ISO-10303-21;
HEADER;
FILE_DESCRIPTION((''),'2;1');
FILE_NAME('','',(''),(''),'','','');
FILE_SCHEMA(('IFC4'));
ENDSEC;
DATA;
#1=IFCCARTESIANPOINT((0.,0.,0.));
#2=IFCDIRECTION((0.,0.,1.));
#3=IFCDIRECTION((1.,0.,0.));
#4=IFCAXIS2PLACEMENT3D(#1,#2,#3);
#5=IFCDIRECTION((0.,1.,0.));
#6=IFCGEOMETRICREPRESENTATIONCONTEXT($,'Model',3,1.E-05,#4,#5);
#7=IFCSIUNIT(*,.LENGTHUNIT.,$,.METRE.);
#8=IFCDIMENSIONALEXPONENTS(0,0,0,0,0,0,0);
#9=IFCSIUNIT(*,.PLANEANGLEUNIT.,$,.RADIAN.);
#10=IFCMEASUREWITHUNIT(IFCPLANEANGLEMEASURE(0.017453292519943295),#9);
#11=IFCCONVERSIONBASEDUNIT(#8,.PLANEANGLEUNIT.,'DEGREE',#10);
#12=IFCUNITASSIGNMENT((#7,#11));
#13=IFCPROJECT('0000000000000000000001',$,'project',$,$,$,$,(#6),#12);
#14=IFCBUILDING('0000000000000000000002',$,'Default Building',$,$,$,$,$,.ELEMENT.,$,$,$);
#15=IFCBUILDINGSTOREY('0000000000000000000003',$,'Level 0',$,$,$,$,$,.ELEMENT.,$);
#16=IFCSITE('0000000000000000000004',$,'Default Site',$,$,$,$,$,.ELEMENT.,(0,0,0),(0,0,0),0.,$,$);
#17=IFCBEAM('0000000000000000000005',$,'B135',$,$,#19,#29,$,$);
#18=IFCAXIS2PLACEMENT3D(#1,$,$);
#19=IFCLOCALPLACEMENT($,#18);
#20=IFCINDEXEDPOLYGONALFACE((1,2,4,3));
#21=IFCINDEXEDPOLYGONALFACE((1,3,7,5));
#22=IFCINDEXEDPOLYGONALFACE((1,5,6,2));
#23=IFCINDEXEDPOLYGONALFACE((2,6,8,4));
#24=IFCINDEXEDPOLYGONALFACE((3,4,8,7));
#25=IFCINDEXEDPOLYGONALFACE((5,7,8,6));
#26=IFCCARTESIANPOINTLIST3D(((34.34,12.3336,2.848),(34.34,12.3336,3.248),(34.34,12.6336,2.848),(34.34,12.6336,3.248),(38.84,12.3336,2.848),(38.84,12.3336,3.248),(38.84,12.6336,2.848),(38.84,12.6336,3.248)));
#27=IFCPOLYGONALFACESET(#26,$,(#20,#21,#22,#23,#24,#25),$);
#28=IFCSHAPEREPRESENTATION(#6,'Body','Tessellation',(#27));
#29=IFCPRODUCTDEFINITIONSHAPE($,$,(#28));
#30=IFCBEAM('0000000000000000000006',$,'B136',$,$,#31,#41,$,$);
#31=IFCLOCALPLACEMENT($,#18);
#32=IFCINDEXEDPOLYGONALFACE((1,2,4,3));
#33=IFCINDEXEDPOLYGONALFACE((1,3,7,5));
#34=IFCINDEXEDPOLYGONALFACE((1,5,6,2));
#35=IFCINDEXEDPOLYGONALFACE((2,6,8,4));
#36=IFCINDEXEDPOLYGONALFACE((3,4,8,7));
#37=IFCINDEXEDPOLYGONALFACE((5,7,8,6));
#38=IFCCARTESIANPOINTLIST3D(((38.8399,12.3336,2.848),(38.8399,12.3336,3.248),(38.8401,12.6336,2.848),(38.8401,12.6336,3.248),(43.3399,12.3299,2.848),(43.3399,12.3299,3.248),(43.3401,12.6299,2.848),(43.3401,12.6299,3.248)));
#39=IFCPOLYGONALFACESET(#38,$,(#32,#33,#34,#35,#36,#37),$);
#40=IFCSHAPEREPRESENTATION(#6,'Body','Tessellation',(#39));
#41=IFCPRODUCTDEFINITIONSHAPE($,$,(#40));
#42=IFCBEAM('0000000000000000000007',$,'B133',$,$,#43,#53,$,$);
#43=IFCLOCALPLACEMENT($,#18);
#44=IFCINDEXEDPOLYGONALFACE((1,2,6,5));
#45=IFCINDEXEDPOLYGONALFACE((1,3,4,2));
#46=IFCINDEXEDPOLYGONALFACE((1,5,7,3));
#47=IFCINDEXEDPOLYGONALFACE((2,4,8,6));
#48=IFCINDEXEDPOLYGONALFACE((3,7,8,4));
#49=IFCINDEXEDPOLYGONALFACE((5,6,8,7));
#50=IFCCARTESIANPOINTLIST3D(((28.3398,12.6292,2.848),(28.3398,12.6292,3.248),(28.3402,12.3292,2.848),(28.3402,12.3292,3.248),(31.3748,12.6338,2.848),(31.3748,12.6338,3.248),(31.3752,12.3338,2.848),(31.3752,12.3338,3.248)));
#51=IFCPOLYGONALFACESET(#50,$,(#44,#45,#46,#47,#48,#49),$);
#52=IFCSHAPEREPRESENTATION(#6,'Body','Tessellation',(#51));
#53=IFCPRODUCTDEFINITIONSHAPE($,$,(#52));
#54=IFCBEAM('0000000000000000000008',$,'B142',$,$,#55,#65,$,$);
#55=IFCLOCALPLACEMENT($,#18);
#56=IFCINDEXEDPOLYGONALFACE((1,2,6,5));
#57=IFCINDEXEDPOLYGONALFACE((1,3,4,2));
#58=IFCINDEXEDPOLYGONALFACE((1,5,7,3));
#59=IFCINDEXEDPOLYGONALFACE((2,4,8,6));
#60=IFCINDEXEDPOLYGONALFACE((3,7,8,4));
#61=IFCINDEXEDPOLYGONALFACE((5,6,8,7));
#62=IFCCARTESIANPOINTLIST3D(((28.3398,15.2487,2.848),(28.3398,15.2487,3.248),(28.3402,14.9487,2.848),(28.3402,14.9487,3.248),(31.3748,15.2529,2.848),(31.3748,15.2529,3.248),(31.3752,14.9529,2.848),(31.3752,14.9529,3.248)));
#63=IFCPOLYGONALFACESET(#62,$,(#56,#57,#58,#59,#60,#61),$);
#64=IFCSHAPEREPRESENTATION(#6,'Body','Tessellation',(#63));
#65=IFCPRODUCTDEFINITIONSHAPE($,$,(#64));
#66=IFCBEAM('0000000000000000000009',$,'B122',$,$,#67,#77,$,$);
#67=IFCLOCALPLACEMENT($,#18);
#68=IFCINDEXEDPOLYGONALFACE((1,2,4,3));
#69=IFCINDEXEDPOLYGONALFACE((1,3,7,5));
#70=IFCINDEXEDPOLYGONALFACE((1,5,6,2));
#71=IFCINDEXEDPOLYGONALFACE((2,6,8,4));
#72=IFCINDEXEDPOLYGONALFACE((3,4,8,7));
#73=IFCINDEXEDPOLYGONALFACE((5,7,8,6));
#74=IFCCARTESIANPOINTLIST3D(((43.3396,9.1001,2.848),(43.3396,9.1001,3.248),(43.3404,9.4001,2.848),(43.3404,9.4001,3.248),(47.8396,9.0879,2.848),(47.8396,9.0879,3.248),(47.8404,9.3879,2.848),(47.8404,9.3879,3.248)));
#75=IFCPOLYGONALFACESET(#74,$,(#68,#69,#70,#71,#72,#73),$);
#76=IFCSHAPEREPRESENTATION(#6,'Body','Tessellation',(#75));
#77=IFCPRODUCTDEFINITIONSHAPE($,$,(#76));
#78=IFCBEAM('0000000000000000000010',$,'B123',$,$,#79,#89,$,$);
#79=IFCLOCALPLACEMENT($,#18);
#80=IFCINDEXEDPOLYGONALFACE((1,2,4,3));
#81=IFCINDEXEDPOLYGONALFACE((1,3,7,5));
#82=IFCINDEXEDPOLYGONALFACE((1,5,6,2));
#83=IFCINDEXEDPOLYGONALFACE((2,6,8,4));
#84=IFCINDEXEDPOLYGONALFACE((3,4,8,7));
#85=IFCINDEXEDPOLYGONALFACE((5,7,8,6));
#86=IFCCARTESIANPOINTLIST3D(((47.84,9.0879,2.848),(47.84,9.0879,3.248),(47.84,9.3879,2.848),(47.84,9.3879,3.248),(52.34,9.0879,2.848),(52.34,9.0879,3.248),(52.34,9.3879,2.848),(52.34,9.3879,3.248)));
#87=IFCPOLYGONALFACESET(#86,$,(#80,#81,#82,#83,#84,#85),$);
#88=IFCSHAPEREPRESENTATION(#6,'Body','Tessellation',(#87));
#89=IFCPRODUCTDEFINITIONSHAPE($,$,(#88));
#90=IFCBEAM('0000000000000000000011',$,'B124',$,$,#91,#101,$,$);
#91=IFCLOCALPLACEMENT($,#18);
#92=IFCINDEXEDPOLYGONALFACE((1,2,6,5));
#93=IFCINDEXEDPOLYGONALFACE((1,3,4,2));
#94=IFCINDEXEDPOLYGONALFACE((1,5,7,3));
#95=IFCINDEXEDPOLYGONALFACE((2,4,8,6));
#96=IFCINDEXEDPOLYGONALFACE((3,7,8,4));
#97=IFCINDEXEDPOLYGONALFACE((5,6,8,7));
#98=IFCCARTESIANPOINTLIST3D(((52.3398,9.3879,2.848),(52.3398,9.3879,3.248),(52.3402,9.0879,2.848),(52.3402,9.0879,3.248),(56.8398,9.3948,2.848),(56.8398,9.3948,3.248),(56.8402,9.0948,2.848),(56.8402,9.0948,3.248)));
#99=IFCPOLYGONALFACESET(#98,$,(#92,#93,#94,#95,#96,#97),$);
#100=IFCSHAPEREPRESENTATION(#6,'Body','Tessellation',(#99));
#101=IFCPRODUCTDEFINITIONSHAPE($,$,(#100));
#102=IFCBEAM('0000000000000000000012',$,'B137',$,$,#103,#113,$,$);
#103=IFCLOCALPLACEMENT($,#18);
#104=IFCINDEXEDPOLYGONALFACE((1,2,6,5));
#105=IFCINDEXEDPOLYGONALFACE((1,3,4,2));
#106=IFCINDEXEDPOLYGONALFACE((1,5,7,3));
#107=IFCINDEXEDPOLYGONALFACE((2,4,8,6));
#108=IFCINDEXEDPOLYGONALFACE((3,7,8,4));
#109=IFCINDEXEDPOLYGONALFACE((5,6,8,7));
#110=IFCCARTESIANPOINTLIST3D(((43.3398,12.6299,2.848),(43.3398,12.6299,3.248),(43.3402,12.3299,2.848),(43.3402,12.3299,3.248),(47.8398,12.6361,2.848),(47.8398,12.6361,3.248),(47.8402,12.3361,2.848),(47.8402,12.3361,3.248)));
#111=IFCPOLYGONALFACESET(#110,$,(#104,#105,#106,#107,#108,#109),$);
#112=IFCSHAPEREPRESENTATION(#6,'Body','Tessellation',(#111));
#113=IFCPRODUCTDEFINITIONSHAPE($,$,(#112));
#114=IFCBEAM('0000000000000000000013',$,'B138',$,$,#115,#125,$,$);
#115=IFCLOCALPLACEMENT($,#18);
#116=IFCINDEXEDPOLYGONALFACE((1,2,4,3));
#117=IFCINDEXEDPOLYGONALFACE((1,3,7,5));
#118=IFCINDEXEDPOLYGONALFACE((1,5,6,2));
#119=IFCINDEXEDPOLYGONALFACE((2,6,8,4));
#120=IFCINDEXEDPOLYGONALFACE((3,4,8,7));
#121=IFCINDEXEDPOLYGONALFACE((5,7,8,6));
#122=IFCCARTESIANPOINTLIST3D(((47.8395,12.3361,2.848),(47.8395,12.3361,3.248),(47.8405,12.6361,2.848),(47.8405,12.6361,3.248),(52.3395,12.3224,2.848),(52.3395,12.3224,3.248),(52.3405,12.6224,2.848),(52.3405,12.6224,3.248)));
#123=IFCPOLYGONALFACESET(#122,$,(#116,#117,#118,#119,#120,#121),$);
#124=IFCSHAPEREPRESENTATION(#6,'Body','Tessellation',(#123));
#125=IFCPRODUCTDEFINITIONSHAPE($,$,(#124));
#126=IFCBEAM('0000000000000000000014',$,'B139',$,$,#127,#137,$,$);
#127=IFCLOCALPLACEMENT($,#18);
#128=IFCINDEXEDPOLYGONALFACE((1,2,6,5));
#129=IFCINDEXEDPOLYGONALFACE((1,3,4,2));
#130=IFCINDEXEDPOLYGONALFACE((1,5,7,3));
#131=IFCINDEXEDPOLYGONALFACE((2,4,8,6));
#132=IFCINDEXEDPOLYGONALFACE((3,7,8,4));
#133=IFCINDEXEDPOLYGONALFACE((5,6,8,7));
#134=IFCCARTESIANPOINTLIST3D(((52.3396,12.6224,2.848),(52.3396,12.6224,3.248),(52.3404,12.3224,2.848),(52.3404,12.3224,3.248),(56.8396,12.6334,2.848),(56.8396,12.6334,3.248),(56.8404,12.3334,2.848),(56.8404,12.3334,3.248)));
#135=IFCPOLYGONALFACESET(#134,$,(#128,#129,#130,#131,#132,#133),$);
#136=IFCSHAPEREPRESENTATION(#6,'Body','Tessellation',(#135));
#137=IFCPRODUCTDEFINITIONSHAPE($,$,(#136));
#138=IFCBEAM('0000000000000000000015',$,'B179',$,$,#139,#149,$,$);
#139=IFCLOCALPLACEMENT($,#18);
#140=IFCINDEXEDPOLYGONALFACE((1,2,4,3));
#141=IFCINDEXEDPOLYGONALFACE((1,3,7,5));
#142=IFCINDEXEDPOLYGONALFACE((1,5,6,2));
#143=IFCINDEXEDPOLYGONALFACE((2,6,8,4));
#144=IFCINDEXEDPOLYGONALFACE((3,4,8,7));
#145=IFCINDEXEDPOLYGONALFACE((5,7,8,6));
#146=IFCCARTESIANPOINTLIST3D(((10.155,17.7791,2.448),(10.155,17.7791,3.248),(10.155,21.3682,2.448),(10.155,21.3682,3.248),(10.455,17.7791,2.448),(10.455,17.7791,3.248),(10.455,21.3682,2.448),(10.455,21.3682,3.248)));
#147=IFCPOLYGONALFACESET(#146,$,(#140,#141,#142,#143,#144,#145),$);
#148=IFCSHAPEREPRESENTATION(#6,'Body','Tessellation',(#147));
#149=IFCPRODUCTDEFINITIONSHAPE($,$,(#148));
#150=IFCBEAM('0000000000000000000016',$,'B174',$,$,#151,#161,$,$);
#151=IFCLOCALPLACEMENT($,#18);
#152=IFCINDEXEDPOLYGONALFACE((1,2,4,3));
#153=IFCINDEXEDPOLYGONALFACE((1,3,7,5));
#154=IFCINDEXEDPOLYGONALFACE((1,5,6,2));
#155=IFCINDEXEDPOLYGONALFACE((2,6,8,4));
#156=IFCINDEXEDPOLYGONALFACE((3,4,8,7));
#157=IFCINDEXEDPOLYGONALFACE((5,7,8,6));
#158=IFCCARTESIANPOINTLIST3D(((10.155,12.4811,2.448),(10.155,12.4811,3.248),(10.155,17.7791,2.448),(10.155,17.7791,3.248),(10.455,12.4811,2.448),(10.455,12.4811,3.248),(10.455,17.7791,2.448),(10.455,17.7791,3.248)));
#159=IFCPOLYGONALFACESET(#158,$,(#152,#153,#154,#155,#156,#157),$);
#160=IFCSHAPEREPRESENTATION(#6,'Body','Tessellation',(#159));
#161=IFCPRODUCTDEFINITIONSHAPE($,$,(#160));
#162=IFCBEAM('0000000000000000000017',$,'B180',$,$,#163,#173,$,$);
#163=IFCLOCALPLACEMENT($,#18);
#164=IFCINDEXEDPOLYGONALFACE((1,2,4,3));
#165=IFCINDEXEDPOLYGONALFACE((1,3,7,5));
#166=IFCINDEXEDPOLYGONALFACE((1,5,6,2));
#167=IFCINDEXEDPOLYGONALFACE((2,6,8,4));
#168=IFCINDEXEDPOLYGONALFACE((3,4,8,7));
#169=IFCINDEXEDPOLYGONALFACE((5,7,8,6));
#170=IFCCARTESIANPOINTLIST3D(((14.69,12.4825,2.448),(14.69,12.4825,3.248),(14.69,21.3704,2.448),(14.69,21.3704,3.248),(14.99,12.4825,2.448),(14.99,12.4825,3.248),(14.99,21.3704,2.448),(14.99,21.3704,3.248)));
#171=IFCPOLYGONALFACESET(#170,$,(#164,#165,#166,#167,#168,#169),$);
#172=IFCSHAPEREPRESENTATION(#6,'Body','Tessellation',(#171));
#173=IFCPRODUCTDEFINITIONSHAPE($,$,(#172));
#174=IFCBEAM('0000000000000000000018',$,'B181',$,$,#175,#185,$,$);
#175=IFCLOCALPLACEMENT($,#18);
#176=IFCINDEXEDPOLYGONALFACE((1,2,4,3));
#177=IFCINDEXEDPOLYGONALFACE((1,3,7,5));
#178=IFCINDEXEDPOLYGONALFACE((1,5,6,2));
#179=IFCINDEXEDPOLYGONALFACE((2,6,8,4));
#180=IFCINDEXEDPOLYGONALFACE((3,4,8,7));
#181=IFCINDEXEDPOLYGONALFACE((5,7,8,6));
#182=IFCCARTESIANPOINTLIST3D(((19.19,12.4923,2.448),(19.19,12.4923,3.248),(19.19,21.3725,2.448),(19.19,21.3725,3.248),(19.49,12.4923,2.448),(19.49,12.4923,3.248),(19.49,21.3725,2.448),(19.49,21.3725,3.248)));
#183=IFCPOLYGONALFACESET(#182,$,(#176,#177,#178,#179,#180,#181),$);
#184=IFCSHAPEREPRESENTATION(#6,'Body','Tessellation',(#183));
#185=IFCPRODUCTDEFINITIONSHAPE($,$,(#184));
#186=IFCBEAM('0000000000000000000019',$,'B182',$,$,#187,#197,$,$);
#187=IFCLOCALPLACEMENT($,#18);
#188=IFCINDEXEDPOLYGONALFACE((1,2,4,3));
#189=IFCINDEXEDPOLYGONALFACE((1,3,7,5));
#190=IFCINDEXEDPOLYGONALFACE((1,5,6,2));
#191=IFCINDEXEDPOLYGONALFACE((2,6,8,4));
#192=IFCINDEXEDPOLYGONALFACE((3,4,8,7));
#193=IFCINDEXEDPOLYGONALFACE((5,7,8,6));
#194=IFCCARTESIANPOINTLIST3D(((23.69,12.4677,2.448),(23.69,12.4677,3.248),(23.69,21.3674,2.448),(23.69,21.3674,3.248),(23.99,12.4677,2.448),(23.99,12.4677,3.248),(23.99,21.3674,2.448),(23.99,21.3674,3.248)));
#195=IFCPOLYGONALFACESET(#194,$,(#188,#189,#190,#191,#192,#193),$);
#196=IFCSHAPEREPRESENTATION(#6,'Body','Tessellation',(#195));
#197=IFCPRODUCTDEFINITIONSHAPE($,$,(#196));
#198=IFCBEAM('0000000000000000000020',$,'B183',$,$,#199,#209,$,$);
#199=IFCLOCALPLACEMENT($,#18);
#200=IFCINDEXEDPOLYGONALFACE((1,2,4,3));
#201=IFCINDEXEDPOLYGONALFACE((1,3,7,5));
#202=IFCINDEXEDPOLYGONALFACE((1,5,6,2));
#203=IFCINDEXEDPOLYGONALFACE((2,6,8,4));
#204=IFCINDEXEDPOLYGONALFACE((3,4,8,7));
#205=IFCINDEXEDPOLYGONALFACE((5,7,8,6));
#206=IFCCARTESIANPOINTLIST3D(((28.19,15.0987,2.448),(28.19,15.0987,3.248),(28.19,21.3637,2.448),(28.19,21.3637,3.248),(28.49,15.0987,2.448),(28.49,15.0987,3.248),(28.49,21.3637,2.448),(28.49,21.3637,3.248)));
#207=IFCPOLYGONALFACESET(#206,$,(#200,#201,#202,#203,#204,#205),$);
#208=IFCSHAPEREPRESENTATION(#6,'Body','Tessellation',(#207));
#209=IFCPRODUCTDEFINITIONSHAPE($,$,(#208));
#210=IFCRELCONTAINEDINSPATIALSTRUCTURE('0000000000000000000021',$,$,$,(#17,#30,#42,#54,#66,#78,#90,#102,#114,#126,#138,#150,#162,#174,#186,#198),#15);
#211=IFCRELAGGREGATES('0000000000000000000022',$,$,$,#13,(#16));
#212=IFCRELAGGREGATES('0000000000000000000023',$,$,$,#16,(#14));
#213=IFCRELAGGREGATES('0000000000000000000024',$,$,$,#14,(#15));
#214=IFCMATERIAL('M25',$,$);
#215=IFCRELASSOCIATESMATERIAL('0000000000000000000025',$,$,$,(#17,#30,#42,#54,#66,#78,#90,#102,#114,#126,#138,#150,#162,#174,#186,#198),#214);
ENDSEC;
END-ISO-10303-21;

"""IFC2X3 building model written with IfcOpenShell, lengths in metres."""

from ifc_helpers import new_model, entity, si_unit, converted_unit, direction, frame, frame_2d, origin_with_axes, place, context, project, spatial, rectangle, extrude, material, element, save


model = new_model("IFC2X3")

# Units and contexts
model_context = context("Model", 3, precision=1e-05, world=origin_with_axes(), true_north=direction((0.0, 1.0, 0.0)))
ifc_project = project(units=[si_unit("LENGTHUNIT", "METRE"), converted_unit("PLANEANGLEUNIT", "DEGREE", entity("IfcPlaneAngleMeasure", 0.017453292519943295), si_unit("PLANEANGLEUNIT", "RADIAN"), dimensions=[0, 0, 0, 0, 0, 0, 0])], contexts=[model_context])

# Site, building, storey
site = spatial("IfcSite", under=ifc_project, Name="Default Site", CompositionType="ELEMENT", RefLatitude=(0, 0, 0), RefLongitude=(0, 0, 0), RefElevation=0.0)
building = spatial("IfcBuilding", under=site, Name="Default Building", CompositionType="ELEMENT")
storey = spatial("IfcBuildingStorey", under=building, Name="Level 0", CompositionType="ELEMENT")

# Beams
ifc_material = material(Name="M25")
placement = place(None, origin_with_axes())
element("IfcBeam", 1, at=placement, inside=storey, material=ifc_material, Name="B135", context=model_context, shape_type="SweptSolid", body=[
    extrude(rectangle(XDim=0.3, YDim=0.4, at=frame_2d((0.0, 0.0), x_axis=(0.0, 1.0, 0.0))), frame((34.34, 12.4836, 3.048), z_axis=(1.0, -0.000008, 0.0), x_axis=(0.0, 0.0, -1.0)), (0.0, 0.0, 1.0), 4.5),
])
element("IfcBeam", 2, at=placement, inside=storey, material=ifc_material, Name="B136", context=model_context, shape_type="SweptSolid", body=[
    extrude(rectangle(XDim=0.3, YDim=0.4, at=frame_2d((0.0, 0.0), x_axis=(0.0, 1.0, 0.0))), frame((38.84, 12.4836, 3.048), z_axis=(1.0, -0.000826, 0.0), x_axis=(0.0, 0.0, -1.0)), (0.0, 0.0, 1.0), 4.5),
])
element("IfcBeam", 3, at=placement, inside=storey, material=ifc_material, Name="B133", context=model_context, shape_type="SweptSolid", body=[
    extrude(rectangle(XDim=0.3, YDim=0.4, at=frame_2d((0.0, 0.0), x_axis=(0.0, 1.0, 0.0))), frame((28.34, 12.4792, 3.048), z_axis=(0.999999, 0.001542, 0.0), x_axis=(0.0, 0.0, -1.0)), (0.0, 0.0, 1.0), 3.035),
])
element("IfcBeam", 4, at=placement, inside=storey, material=ifc_material, Name="B142", context=model_context, shape_type="SweptSolid", body=[
    extrude(rectangle(XDim=0.3, YDim=0.4, at=frame_2d((0.0, 0.0), x_axis=(0.0, 1.0, 0.0))), frame((31.375, 15.1029, 3.048), z_axis=(-0.999999, -0.001391, 0.0), x_axis=(0.0, 0.0, -1.0)), (0.0, 0.0, 1.0), 3.035),
])
element("IfcBeam", 5, at=placement, inside=storey, material=ifc_material, Name="B122", context=model_context, shape_type="SweptSolid", body=[
    extrude(rectangle(XDim=0.3, YDim=0.4, at=frame_2d((0.0, 0.0), x_axis=(0.0, 1.0, 0.0))), frame((43.34, 9.2501, 3.048), z_axis=(0.999996, -0.002702, 0.0), x_axis=(0.0, 0.0, -1.0)), (0.0, 0.0, 1.0), 4.5),
])
element("IfcBeam", 6, at=placement, inside=storey, material=ifc_material, Name="B123", context=model_context, shape_type="SweptSolid", body=[
    extrude(rectangle(XDim=0.3, YDim=0.4, at=frame_2d((0.0, 0.0), x_axis=(0.0, 1.0, 0.0))), frame((47.84, 9.2379, 3.048), z_axis=(1.0, 0.0, 0.0), x_axis=(0.0, 0.0, -1.0)), (0.0, 0.0, 1.0), 4.5),
])
element("IfcBeam", 7, at=placement, inside=storey, material=ifc_material, Name="B124", context=model_context, shape_type="SweptSolid", body=[
    extrude(rectangle(XDim=0.3, YDim=0.4, at=frame_2d((0.0, 0.0), x_axis=(0.0, 1.0, 0.0))), frame((52.34, 9.2379, 3.048), z_axis=(0.999999, 0.001537, 0.0), x_axis=(0.0, 0.0, -1.0)), (0.0, 0.0, 1.0), 4.5),
])
element("IfcBeam", 8, at=placement, inside=storey, material=ifc_material, Name="B137", context=model_context, shape_type="SweptSolid", body=[
    extrude(rectangle(XDim=0.3, YDim=0.4, at=frame_2d((0.0, 0.0), x_axis=(0.0, 1.0, 0.0))), frame((43.34, 12.4799, 3.048), z_axis=(0.999999, 0.001374, 0.0), x_axis=(0.0, 0.0, -1.0)), (0.0, 0.0, 1.0), 4.5),
])
element("IfcBeam", 9, at=placement, inside=storey, material=ifc_material, Name="B138", context=model_context, shape_type="SweptSolid", body=[
    extrude(rectangle(XDim=0.3, YDim=0.4, at=frame_2d((0.0, 0.0), x_axis=(0.0, 1.0, 0.0))), frame((47.84, 12.4861, 3.048), z_axis=(0.999995, -0.003045, 0.0), x_axis=(0.0, 0.0, -1.0)), (0.0, 0.0, 1.0), 4.5),
])
element("IfcBeam", 10, at=placement, inside=storey, material=ifc_material, Name="B139", context=model_context, shape_type="SweptSolid", body=[
    extrude(rectangle(XDim=0.3, YDim=0.4, at=frame_2d((0.0, 0.0), x_axis=(0.0, 1.0, 0.0))), frame((52.34, 12.4724, 3.048), z_axis=(0.999997, 0.002456, 0.0), x_axis=(0.0, 0.0, -1.0)), (0.0, 0.0, 1.0), 4.5),
])
element("IfcBeam", 11, at=placement, inside=storey, material=ifc_material, Name="B179", context=model_context, shape_type="SweptSolid", body=[
    extrude(rectangle(XDim=0.3, YDim=0.8, at=frame_2d((0.0, 0.0), x_axis=(0.0, 1.0, 0.0))), frame((10.305, 21.3682, 2.848), z_axis=(0.0, -1.0, 0.0), x_axis=(0.0, 0.0, -1.0)), (0.0, 0.0, 1.0), 3.5891),
])
element("IfcBeam", 12, at=placement, inside=storey, material=ifc_material, Name="B174", context=model_context, shape_type="SweptSolid", body=[
    extrude(rectangle(XDim=0.3, YDim=0.8, at=frame_2d((0.0, 0.0), x_axis=(0.0, 1.0, 0.0))), frame((10.305, 17.7791, 2.848), z_axis=(0.0, -1.0, 0.0), x_axis=(0.0, 0.0, -1.0)), (0.0, 0.0, 1.0), 5.298),
])
element("IfcBeam", 13, at=placement, inside=storey, material=ifc_material, Name="B180", context=model_context, shape_type="SweptSolid", body=[
    extrude(rectangle(XDim=0.3, YDim=0.8, at=frame_2d((0.0, 0.0), x_axis=(0.0, 1.0, 0.0))), frame((14.84, 21.3704, 2.848), z_axis=(0.0, -1.0, 0.0), x_axis=(0.0, 0.0, -1.0)), (0.0, 0.0, 1.0), 8.8879),
])
element("IfcBeam", 14, at=placement, inside=storey, material=ifc_material, Name="B181", context=model_context, shape_type="SweptSolid", body=[
    extrude(rectangle(XDim=0.3, YDim=0.8, at=frame_2d((0.0, 0.0), x_axis=(0.0, 1.0, 0.0))), frame((19.34, 21.3725, 2.848), z_axis=(0.0, -1.0, 0.0), x_axis=(0.0, 0.0, -1.0)), (0.0, 0.0, 1.0), 8.8802),
])
element("IfcBeam", 15, at=placement, inside=storey, material=ifc_material, Name="B182", context=model_context, shape_type="SweptSolid", body=[
    extrude(rectangle(XDim=0.3, YDim=0.8, at=frame_2d((0.0, 0.0), x_axis=(0.0, 1.0, 0.0))), frame((23.84, 21.3674, 2.848), z_axis=(0.0, -1.0, 0.0), x_axis=(0.0, 0.0, -1.0)), (0.0, 0.0, 1.0), 8.8997),
])
element("IfcBeam", 16, at=placement, inside=storey, material=ifc_material, Name="B183", context=model_context, shape_type="SweptSolid", body=[
    extrude(rectangle(XDim=0.3, YDim=0.8, at=frame_2d((0.0, 0.0), x_axis=(0.0, 1.0, 0.0))), frame((28.34, 21.3637, 2.848), z_axis=(0.0, -1.0, 0.0), x_axis=(0.0, 0.0, -1.0)), (0.0, 0.0, 1.0), 6.265),
])

save(model, "model.ifc")
